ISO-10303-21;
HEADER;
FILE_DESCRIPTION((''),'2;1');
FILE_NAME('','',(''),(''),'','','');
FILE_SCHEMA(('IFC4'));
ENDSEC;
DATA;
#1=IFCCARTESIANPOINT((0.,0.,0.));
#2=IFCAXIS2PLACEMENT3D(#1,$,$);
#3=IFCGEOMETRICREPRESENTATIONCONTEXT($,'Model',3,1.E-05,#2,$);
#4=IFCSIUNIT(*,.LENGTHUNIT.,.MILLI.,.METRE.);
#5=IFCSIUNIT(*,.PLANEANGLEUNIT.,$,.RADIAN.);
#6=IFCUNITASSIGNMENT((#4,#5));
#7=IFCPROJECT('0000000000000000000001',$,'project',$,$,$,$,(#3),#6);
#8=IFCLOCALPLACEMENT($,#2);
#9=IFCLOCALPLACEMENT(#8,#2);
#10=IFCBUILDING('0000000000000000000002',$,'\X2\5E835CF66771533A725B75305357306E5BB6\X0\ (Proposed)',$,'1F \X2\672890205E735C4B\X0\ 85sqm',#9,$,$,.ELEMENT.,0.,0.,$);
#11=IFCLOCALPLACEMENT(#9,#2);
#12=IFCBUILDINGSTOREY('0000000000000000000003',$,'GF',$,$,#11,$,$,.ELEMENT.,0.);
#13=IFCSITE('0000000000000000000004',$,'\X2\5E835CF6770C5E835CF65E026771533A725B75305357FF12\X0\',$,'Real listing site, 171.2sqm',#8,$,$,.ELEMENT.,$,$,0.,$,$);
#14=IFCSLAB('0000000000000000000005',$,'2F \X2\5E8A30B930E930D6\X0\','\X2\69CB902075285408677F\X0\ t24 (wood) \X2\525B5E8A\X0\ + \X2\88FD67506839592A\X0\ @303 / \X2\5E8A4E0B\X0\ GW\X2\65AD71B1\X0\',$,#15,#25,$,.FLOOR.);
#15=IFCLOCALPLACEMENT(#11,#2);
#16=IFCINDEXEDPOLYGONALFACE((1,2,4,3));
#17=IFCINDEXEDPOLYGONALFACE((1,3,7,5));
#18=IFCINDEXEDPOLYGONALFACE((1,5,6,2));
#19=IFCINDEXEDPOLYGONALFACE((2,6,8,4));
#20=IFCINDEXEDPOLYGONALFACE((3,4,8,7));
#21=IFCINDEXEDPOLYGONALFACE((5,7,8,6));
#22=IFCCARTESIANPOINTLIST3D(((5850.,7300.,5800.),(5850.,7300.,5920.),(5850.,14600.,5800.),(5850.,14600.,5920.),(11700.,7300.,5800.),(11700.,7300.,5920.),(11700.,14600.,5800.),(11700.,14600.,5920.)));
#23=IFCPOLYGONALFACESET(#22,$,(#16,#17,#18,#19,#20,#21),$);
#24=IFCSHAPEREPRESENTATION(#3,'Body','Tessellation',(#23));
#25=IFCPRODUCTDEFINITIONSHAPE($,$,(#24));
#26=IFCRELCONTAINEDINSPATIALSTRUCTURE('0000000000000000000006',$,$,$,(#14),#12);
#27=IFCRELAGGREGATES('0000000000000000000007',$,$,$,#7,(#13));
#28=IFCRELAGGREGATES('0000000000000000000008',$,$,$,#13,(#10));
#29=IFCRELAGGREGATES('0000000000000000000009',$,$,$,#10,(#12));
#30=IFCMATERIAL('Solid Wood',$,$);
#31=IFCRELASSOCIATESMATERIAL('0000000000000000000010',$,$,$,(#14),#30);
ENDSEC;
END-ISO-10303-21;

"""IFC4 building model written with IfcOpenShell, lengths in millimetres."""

from ifc_helpers import new_model, si_unit, frame, frame_2d, origin, place, context, project, spatial, rectangle, extrude, material, element, save


model = new_model("IFC4")

# Units and contexts
model_context = context("Model", 3, precision=1e-05, world=origin())
ifc_project = project(units=[si_unit("LENGTHUNIT", "METRE", prefix="MILLI"), si_unit("PLANEANGLEUNIT", "RADIAN")], contexts=[model_context])

# Site, building, storey
site_placement = place(None, origin())
site = spatial("IfcSite", under=ifc_project, at=site_placement, Name="広島県広島市東区牛田南２", ObjectType="Real listing site, 171.2sqm", CompositionType="ELEMENT", RefElevation=0.0)
building_placement = place(site_placement, origin())
building = spatial("IfcBuilding", under=site, at=building_placement, Name="広島東区牛田南の家 (Proposed)", ObjectType="1F 木造平屋 85sqm", CompositionType="ELEMENT", ElevationOfRefHeight=0.0, ElevationOfTerrain=0.0)
storey_placement = place(building_placement, origin())
storey = spatial("IfcBuildingStorey", under=building, at=storey_placement, Name="GF", CompositionType="ELEMENT", Elevation=0.0)

# Slab
ifc_material_1 = material(Name="Solid Wood")
slab_placement = place(storey_placement, frame((2925.0, 3650.0, 2900.0)))
element("IfcSlab", 1, at=slab_placement, inside=storey, material=ifc_material_1, Name="2F 床スラブ", Description="構造用合板 t24 (wood) 剛床 + 製材根太 @303 / 床下 GW断熱", PredefinedType="FLOOR", context=model_context, shape_type="SweptSolid", body=[
    extrude(rectangle(XDim=5850.0, YDim=7300.0, at=frame_2d((2925.0, 3650.0))), frame((2925.0, 3650.0, 2900.0)), (0.0, 0.0, 1.0), 120.0),
])

save(model, "model.ifc")
